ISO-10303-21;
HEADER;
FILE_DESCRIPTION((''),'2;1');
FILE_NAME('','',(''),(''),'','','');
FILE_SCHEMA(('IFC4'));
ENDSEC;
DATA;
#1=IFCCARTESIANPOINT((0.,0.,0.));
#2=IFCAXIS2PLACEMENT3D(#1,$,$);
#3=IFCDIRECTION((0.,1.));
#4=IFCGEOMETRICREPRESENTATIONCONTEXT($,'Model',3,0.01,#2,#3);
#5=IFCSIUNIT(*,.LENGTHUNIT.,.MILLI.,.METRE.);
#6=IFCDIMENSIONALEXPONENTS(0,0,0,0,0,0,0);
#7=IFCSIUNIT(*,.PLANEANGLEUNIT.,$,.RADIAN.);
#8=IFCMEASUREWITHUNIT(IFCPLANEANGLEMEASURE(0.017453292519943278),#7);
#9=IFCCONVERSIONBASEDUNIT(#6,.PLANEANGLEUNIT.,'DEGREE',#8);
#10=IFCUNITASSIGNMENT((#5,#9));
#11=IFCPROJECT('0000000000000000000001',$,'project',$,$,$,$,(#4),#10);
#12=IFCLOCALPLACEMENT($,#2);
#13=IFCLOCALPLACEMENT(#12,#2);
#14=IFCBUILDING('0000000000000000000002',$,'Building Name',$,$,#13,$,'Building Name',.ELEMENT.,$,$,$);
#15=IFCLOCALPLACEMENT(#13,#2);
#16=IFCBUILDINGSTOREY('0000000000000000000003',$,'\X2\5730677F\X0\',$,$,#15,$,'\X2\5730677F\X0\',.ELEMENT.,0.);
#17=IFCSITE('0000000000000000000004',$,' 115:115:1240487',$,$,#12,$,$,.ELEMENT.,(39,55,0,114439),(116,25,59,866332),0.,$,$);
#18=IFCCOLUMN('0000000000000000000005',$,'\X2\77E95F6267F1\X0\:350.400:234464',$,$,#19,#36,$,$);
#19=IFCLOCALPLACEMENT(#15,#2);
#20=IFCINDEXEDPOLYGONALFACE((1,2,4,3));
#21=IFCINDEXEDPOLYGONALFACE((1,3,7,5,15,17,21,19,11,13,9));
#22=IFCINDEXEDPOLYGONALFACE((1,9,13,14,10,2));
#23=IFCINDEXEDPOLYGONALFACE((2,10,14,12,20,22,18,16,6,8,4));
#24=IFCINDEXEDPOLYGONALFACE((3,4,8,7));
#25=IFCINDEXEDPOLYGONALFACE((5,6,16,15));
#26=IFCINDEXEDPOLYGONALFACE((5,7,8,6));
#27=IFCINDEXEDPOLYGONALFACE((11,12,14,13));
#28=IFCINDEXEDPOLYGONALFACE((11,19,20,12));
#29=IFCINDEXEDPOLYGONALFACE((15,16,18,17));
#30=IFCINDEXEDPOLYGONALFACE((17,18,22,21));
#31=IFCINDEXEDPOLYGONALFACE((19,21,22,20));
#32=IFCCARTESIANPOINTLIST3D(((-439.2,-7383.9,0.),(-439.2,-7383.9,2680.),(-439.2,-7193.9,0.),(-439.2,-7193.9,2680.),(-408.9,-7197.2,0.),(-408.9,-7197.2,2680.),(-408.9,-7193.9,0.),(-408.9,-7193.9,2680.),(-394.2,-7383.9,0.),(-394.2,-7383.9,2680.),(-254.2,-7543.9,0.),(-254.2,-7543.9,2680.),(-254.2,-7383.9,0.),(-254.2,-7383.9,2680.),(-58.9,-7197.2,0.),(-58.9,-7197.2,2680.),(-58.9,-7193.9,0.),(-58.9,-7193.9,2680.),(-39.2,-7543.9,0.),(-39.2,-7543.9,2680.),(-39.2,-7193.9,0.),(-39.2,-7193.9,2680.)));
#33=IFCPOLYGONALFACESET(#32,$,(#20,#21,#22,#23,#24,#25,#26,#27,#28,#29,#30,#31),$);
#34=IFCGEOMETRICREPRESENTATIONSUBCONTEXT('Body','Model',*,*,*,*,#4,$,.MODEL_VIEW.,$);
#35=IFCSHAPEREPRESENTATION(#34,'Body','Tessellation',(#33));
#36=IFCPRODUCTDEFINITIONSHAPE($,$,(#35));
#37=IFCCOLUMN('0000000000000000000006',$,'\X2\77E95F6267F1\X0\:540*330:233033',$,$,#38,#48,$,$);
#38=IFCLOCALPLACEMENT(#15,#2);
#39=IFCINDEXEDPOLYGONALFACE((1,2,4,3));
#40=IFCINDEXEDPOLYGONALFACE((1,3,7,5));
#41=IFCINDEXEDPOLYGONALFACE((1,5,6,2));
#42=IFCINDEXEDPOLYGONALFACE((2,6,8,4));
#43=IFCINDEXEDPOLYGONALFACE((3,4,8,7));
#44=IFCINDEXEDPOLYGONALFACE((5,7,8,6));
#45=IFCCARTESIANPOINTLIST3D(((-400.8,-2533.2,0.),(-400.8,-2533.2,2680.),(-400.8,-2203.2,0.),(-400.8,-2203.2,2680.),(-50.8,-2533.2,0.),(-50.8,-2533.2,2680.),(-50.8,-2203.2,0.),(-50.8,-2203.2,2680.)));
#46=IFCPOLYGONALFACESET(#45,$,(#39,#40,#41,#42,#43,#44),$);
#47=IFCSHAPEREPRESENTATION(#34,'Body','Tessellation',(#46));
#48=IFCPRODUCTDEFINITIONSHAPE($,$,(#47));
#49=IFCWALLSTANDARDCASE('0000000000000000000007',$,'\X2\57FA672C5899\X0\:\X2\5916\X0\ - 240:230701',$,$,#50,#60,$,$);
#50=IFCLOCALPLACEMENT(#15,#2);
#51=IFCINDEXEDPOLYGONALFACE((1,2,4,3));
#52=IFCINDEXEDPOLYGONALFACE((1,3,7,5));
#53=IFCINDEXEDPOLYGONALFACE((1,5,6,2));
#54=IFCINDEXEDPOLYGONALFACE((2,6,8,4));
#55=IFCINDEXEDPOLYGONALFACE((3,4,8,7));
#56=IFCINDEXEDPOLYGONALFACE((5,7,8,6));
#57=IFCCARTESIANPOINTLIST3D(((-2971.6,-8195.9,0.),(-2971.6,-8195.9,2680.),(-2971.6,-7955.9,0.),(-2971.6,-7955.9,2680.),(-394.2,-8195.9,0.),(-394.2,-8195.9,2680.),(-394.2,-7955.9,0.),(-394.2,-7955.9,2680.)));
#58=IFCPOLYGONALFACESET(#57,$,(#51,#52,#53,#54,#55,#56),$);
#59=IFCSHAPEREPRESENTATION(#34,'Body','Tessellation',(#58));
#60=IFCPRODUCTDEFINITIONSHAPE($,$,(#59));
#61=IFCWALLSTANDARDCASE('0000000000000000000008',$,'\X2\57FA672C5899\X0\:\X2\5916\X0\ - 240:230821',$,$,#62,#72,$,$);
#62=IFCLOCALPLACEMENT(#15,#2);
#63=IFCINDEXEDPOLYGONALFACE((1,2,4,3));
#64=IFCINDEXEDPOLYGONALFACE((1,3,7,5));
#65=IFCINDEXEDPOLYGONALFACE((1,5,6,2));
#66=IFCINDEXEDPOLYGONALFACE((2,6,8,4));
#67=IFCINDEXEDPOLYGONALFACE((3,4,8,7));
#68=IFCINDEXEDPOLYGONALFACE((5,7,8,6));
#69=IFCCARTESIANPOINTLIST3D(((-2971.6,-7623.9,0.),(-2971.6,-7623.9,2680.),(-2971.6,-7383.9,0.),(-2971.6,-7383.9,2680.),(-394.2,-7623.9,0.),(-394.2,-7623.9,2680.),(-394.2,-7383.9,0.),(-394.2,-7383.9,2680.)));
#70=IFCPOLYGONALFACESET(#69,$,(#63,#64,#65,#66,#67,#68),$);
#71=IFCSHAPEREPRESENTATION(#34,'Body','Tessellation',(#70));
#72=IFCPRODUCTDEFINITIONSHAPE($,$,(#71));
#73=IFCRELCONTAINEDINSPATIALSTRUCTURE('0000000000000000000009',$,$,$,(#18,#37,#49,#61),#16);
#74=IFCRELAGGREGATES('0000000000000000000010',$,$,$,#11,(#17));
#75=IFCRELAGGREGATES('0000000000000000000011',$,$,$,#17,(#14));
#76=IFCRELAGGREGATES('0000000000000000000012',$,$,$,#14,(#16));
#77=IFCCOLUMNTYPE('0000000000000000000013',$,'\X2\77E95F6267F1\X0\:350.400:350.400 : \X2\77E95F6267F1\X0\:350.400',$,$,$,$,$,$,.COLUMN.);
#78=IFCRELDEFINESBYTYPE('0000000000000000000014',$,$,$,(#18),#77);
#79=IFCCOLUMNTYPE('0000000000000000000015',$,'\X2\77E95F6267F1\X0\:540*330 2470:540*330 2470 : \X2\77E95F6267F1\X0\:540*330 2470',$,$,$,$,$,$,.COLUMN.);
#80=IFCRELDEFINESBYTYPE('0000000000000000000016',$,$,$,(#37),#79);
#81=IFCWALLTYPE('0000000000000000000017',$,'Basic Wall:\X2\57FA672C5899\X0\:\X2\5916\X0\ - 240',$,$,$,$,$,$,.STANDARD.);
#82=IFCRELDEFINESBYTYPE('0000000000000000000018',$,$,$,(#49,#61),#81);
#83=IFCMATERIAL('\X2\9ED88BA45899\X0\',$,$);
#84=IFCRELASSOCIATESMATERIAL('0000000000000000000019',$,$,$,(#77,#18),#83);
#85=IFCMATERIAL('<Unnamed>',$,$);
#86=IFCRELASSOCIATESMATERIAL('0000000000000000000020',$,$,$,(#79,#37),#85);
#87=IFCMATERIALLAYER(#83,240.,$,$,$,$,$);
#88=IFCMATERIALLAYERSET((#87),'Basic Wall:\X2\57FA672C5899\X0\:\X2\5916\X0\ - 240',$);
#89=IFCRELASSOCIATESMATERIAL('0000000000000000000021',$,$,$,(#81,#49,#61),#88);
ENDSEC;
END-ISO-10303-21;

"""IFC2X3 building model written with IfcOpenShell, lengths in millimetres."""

from ifc_helpers import new_model, entity, si_unit, converted_unit, direction, frame, frame_2d, origin, place, context, subcontext, project, spatial, polyline, rectangle, outline, extrude, source, transform, mapped, material, layer, layer_set, layer_usage, type_object, type_shapes, element, save


model = new_model("IFC2X3")

# Units and contexts
model_context = context("Model", 3, precision=0.01, world=origin(), true_north=direction((0.0, 1.0)))
body_context = subcontext(model_context, "Body", "Model", "MODEL_VIEW")
ifc_project = project(units=[si_unit("LENGTHUNIT", "METRE", prefix="MILLI"), converted_unit("PLANEANGLEUNIT", "DEGREE", entity("IfcPlaneAngleMeasure", 0.017453292519943278), si_unit("PLANEANGLEUNIT", "RADIAN"), dimensions=[0, 0, 0, 0, 0, 0, 0])], contexts=[model_context])

# Site, building, storey
site_placement = place(None, origin())
site = spatial("IfcSite", under=ifc_project, at=site_placement, Name=" 115:115:1240487", CompositionType="ELEMENT", RefLatitude=(39, 55, 0, 114439), RefLongitude=(116, 25, 59, 866332), RefElevation=0.0)
building_placement = place(site_placement, origin())
building = spatial("IfcBuilding", under=site, at=building_placement, Name="Building Name", LongName="Building Name", CompositionType="ELEMENT")
storey_placement = place(building_placement, origin())
storey = spatial("IfcBuildingStorey", under=building, at=storey_placement, Name="地板", LongName="地板", CompositionType="ELEMENT", Elevation=0.0)

# Columns
ifc_material_1 = material(Name="默认墙")
column_type_1 = type_object("IfcColumnType", Name="矩形柱:350.400:350.400 : 矩形柱:350.400", PredefinedType="COLUMN", material=ifc_material_1)
shared_shape_1 = source(origin(), body_context, "Body", "SweptSolid", [
    extrude(outline(polyline([(-185.1, 73.9), (-185.1, -116.1), (-154.8, -116.1), (-154.8, -112.7), (195.2, -112.7), (195.2, -116.1), (214.9, -116.1), (214.9, 233.9), (-0.1, 233.9), (-0.1, 73.9), (-140.1, 73.9), (-185.1, 73.9)])), frame((-254.1, -7309.9, 0.0), z_axis=(0.0, 0.0, -1.0), x_axis=(1.0, 0.0, 0.0)), (0.0, 0.0, -1.0), 2680.0),
])
type_shapes(column_type_1, [shared_shape_1])
column_1_placement = place(storey_placement, origin())
element("IfcColumn", 1, at=column_1_placement, inside=storey, type_object=column_type_1, material=ifc_material_1, Name="矩形柱:350.400:234464", context=body_context, shape_type="MappedRepresentation", body=[
    mapped(shared_shape_1, transform((0.0, 0.0, 0.0), scale=1.0)),
])
ifc_material_2 = material(Name="<Unnamed>")
column_type_2 = type_object("IfcColumnType", Name="矩形柱:540*330 2470:540*330 2470 : 矩形柱:540*330 2470", PredefinedType="COLUMN", material=ifc_material_2)
shared_shape_2 = source(origin(), body_context, "Body", "SweptSolid", [
    extrude(rectangle(XDim=350.0, YDim=330.0, at=frame_2d((0.0, 0.0), x_axis=(1.0, 0.0))), frame((-225.8, -2368.2, 0.0)), (0.0, 0.0, 1.0), 2680.0),
])
type_shapes(column_type_2, [shared_shape_2])
column_2_placement = place(storey_placement, origin())
element("IfcColumn", 2, at=column_2_placement, inside=storey, type_object=column_type_2, material=ifc_material_2, Name="矩形柱:540*330:233033", context=body_context, shape_type="MappedRepresentation", body=[
    mapped(shared_shape_2, transform((0.0, 0.0, 0.0), scale=1.0)),
])

# Walls
ifc_layer_1 = layer(ifc_material_1, 240.0)
ifc_layer_set_1 = layer_set([ifc_layer_1], Name="Basic Wall:基本墙:外 - 240")
ifc_layer_usage_1 = layer_usage(ifc_layer_set_1, "AXIS2", "NEGATIVE", 120.0)
wall_type_1 = type_object("IfcWallType", Name="Basic Wall:基本墙:外 - 240", PredefinedType="STANDARD", material=ifc_layer_set_1)
wall_1_placement = place(storey_placement, frame((-2971.6, -8075.9, 0.0)))
element("IfcWallStandardCase", 3, at=wall_1_placement, inside=storey, type_object=wall_type_1, material=ifc_layer_usage_1, Name="基本墙:外 - 240:230701", context=body_context, shape_type="SweptSolid", body=[
    extrude(rectangle(XDim=2577.4, YDim=240.0, at=frame_2d((1288.7, 0.0), x_axis=(-1.0, 0.0))), origin(), (0.0, 0.0, 1.0), 2680.0),
])
ifc_layer_usage_2 = layer_usage(ifc_layer_set_1, "AXIS2", "NEGATIVE", 120.0)
wall_2_placement = place(storey_placement, frame((-2971.6, -7503.9, 0.0)))
element("IfcWallStandardCase", 4, at=wall_2_placement, inside=storey, type_object=wall_type_1, material=ifc_layer_usage_2, Name="基本墙:外 - 240:230821", context=body_context, shape_type="SweptSolid", body=[
    extrude(rectangle(XDim=2577.4, YDim=240.0, at=frame_2d((1288.7, 0.0), x_axis=(-1.0, 0.0))), origin(), (0.0, 0.0, 1.0), 2680.0),
])

save(model, "model.ifc")
